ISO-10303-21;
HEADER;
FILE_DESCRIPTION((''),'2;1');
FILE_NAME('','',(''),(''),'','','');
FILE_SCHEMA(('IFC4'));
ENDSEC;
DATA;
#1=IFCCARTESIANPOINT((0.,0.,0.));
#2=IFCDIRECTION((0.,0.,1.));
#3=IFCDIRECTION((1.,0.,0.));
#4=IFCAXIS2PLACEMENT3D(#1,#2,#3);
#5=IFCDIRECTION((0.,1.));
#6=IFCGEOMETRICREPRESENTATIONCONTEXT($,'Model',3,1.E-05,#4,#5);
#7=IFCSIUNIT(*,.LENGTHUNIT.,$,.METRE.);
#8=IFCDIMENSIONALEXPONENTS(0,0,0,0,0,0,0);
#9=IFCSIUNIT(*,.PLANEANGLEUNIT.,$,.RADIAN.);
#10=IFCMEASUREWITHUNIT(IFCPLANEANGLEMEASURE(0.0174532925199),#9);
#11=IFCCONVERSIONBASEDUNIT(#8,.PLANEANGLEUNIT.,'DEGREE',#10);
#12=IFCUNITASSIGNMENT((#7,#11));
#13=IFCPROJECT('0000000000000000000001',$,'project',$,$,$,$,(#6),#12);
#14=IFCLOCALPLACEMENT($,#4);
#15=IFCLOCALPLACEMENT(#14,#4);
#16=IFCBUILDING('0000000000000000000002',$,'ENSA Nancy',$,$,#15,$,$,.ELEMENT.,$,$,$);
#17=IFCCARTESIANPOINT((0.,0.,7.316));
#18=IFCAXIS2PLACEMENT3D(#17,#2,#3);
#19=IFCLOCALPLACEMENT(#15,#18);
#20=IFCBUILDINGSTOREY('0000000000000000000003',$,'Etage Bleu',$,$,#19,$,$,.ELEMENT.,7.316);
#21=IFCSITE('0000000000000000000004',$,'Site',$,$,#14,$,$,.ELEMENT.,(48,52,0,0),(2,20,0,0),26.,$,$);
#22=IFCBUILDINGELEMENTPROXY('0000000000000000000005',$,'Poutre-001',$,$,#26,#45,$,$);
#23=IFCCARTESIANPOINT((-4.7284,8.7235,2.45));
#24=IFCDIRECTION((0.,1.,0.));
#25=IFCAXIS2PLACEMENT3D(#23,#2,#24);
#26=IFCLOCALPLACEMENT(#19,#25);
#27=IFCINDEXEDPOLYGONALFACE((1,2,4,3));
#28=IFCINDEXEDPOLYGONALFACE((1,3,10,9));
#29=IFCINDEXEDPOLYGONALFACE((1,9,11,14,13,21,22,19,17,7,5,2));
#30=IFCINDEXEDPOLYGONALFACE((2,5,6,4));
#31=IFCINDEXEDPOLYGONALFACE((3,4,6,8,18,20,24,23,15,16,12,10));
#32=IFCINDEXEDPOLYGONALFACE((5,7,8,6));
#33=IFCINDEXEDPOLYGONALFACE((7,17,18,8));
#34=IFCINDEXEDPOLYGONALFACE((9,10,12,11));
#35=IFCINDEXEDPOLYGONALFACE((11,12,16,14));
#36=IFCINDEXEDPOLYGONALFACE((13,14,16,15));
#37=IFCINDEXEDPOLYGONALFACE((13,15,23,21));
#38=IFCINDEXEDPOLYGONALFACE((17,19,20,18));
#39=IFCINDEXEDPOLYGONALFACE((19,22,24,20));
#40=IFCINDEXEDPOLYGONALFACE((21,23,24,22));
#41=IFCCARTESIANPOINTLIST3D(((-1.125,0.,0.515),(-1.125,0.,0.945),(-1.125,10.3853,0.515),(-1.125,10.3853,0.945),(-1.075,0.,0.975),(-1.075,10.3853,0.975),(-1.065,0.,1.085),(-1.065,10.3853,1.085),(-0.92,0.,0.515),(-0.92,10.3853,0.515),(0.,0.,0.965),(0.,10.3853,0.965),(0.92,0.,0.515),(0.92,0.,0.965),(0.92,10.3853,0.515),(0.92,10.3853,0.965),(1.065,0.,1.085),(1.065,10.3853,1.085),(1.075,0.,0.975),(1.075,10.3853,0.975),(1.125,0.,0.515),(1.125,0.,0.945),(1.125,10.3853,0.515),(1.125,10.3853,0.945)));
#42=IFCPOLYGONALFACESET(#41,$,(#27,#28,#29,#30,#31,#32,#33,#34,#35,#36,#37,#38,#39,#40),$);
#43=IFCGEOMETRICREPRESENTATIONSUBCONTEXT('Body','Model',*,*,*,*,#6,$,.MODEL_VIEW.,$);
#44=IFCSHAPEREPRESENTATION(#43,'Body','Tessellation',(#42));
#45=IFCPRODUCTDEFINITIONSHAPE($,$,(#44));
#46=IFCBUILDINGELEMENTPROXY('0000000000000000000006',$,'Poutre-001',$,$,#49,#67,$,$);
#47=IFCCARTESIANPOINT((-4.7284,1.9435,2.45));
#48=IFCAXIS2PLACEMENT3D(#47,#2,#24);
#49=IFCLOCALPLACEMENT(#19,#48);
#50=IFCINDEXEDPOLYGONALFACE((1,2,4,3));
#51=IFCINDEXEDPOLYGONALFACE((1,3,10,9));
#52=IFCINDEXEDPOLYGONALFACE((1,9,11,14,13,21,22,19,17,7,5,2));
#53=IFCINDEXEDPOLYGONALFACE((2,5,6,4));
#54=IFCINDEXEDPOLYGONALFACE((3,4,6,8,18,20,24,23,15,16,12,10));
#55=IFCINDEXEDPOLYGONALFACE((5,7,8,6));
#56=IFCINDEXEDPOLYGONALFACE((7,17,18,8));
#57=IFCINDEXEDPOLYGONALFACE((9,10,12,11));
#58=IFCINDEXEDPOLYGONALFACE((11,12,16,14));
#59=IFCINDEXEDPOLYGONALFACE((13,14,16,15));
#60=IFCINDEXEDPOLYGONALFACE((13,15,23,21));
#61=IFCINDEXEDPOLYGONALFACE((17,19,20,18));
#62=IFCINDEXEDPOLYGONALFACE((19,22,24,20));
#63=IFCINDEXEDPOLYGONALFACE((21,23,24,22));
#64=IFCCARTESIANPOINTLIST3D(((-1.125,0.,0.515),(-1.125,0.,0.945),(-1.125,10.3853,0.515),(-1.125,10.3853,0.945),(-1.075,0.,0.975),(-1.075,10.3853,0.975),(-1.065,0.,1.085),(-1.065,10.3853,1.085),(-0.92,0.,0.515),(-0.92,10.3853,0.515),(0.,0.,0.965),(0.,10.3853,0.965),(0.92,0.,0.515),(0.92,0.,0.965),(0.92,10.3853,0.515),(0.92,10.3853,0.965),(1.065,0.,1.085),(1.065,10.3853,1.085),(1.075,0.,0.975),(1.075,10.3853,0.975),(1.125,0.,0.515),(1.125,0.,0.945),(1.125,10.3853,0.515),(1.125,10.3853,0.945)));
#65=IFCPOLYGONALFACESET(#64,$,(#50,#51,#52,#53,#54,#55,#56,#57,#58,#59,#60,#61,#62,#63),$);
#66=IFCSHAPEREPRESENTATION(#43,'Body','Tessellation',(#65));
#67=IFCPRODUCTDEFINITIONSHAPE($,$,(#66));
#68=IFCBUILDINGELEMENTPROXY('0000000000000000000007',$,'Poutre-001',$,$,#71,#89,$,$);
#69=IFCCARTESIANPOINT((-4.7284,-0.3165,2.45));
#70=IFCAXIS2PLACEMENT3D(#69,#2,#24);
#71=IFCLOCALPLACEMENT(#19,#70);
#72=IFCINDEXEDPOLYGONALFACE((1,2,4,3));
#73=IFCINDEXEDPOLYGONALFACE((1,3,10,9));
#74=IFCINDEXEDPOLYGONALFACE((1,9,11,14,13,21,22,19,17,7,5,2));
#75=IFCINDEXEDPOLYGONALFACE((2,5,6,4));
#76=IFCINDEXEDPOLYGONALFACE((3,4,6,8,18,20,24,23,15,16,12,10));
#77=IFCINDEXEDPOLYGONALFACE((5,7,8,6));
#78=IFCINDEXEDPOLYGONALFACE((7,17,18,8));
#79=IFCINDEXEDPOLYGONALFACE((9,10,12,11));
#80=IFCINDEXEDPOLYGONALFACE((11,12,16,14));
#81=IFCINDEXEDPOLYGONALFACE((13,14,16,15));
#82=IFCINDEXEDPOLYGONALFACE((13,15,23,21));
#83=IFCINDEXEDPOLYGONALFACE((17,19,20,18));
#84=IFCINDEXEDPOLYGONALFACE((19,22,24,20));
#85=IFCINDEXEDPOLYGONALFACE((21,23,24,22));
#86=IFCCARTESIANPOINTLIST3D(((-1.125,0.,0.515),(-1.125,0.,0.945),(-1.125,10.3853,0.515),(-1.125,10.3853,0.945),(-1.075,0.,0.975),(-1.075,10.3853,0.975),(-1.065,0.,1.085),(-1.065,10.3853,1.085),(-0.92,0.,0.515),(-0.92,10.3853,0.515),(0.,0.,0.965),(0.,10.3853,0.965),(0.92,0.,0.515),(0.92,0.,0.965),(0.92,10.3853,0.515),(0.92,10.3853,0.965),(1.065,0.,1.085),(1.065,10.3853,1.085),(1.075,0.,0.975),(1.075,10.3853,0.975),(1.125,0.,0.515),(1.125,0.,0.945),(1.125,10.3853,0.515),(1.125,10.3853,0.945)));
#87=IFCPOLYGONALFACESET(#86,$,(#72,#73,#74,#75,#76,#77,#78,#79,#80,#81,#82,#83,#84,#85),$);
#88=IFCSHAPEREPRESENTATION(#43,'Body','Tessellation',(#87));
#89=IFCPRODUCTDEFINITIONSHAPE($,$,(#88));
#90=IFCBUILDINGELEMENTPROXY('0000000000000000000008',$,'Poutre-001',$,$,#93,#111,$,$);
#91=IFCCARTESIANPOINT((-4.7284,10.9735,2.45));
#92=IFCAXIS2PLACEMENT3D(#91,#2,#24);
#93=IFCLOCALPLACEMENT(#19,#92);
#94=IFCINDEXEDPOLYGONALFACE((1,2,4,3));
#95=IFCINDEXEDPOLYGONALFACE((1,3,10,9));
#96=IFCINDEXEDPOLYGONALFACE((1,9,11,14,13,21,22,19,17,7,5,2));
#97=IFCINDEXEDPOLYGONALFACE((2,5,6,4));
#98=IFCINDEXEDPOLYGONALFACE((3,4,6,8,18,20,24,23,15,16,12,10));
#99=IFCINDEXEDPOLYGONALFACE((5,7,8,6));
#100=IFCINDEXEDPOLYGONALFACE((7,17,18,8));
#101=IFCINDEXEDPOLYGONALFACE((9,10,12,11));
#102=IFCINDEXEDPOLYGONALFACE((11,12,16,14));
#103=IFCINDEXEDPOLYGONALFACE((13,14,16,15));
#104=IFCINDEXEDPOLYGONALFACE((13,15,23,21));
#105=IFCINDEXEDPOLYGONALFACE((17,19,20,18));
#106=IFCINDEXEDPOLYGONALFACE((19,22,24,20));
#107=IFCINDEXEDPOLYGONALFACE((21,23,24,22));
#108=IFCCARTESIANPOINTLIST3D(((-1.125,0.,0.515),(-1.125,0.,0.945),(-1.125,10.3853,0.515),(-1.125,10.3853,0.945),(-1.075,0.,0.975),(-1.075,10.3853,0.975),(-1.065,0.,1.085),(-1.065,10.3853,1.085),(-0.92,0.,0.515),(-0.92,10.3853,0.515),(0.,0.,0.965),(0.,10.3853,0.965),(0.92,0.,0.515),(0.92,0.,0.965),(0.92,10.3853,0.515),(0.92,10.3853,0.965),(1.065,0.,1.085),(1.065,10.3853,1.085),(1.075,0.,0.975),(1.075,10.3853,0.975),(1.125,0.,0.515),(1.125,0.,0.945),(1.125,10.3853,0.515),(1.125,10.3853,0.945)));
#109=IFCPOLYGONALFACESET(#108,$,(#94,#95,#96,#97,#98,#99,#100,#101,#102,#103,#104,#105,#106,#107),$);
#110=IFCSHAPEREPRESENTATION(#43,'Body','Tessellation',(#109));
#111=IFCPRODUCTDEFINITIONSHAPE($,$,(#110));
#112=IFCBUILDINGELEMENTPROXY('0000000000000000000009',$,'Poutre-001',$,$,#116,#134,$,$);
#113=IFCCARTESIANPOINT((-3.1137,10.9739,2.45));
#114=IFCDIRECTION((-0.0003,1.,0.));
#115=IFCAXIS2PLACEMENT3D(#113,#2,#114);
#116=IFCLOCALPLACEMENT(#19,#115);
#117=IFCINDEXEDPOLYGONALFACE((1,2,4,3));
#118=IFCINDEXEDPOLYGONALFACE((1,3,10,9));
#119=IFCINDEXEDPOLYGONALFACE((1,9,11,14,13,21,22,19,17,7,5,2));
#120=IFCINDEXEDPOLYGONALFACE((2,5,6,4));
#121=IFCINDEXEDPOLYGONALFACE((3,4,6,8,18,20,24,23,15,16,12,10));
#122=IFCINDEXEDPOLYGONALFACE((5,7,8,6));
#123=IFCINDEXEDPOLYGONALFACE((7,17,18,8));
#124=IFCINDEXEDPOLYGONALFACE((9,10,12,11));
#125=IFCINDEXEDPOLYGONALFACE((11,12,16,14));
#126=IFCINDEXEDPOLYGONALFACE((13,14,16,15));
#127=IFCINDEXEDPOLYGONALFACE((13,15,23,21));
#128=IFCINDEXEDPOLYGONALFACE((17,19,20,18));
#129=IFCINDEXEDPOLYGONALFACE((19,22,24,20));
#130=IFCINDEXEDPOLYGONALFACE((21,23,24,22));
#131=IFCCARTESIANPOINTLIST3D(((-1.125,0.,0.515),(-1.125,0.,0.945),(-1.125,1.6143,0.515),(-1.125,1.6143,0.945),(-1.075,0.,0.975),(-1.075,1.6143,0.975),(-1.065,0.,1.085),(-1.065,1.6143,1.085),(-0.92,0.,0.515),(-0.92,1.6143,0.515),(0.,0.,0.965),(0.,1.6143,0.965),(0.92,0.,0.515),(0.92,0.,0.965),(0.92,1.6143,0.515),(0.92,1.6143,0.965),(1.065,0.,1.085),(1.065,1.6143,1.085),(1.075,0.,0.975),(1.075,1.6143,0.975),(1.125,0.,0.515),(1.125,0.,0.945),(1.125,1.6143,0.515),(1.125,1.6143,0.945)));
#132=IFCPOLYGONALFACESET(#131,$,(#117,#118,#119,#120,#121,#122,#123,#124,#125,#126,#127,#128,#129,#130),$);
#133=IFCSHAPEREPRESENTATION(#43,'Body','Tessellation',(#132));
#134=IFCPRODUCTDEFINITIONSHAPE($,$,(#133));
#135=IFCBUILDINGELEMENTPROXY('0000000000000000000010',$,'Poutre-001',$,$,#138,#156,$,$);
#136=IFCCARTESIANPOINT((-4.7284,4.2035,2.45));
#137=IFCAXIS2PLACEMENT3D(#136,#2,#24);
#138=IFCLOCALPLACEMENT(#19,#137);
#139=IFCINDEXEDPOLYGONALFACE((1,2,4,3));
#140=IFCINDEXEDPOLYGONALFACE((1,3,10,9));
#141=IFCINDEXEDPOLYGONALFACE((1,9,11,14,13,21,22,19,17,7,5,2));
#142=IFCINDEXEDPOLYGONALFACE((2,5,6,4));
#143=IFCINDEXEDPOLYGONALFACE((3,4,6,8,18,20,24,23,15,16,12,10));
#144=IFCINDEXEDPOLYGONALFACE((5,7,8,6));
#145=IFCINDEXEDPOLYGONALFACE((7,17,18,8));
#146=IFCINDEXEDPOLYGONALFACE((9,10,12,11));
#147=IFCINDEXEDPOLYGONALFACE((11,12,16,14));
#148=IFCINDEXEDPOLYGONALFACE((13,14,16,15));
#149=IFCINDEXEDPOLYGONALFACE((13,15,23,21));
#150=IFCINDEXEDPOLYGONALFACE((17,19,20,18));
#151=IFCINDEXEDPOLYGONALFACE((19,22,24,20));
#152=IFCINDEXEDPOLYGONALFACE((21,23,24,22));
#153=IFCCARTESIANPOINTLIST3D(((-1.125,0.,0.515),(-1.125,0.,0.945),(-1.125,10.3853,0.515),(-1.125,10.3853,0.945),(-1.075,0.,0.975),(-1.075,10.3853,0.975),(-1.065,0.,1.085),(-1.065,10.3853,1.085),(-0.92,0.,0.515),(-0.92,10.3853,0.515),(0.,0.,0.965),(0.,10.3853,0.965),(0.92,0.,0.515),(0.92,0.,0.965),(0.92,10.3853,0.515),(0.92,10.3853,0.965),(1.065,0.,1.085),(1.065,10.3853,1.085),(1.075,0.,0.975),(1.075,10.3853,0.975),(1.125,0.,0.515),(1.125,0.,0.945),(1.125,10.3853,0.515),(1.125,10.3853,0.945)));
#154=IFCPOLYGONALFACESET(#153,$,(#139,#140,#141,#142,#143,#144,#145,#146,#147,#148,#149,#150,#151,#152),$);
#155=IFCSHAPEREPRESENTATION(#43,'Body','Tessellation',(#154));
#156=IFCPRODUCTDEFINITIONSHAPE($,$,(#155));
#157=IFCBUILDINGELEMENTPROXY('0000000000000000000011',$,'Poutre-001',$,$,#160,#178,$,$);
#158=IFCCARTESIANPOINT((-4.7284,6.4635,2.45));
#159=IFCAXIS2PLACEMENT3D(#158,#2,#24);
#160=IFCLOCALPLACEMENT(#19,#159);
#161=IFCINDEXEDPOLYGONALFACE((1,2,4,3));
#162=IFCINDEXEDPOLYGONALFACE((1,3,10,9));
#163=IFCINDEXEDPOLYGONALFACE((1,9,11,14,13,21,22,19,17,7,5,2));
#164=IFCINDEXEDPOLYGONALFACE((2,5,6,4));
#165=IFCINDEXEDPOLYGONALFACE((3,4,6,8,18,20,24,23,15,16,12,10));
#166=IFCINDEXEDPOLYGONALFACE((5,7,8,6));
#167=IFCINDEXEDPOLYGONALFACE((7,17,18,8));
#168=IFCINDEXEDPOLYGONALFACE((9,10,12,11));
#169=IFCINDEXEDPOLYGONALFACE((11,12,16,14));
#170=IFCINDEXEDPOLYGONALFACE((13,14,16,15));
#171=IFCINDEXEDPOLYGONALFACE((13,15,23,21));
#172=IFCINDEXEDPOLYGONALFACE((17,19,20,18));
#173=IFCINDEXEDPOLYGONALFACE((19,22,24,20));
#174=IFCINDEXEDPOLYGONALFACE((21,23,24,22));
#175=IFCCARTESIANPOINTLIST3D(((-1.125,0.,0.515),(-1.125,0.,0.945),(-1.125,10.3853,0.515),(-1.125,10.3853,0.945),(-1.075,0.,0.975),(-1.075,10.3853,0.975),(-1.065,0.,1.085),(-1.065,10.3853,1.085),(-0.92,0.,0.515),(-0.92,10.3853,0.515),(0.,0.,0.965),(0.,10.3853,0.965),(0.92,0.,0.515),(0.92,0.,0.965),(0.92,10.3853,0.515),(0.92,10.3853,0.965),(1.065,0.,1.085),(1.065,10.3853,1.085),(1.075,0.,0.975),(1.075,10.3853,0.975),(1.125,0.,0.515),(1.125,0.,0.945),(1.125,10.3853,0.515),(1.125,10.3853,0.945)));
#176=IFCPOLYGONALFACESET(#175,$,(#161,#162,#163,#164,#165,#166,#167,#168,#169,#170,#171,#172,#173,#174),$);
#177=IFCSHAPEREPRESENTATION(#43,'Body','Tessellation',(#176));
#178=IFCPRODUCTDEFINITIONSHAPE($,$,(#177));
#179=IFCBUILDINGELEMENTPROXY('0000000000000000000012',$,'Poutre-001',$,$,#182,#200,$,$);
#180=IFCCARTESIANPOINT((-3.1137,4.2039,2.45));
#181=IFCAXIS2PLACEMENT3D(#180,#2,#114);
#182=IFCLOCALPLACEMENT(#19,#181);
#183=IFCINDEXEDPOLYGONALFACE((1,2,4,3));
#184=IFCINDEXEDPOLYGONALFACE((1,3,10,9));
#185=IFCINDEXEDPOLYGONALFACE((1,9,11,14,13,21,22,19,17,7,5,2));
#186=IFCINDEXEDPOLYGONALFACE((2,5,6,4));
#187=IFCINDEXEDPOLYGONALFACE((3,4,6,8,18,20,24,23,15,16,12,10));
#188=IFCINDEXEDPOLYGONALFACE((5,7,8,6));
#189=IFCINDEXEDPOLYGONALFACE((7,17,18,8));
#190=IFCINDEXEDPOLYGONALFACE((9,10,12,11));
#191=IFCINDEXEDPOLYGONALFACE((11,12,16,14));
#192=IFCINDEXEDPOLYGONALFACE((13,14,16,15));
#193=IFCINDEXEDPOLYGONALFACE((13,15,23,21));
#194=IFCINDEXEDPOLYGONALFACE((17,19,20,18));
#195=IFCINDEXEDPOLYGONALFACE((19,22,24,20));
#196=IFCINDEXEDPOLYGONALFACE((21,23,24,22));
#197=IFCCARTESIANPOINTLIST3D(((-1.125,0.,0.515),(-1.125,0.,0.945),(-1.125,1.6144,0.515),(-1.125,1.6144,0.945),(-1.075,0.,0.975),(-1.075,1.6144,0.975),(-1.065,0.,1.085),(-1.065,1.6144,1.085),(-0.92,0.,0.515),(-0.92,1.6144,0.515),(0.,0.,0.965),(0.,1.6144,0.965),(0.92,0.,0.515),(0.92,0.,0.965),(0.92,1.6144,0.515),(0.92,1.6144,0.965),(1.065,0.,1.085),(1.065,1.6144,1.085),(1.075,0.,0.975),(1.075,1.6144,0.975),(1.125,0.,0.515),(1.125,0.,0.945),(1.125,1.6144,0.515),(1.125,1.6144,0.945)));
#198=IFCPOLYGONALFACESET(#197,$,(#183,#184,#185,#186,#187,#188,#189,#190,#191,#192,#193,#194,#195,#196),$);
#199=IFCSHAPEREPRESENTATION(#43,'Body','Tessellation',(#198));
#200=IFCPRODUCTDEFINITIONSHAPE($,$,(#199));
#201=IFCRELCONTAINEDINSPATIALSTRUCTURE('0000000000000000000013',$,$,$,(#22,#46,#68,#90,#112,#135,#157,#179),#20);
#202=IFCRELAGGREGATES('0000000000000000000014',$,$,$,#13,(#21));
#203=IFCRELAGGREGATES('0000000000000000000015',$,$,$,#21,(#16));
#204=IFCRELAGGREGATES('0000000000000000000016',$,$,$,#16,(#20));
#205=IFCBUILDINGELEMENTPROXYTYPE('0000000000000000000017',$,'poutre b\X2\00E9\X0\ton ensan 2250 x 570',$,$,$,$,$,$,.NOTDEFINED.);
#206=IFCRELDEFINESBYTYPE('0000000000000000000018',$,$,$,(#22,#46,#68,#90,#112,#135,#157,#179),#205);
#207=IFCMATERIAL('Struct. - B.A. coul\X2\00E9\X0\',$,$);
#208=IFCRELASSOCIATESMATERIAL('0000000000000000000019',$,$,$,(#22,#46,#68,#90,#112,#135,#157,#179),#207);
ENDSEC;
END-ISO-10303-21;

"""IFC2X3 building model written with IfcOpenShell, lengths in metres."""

from ifc_helpers import new_model, entity, si_unit, converted_unit, direction, frame, origin_with_axes, place, context, subcontext, project, spatial, polyline, outline, extrude, material, type_object, element, save


model = new_model("IFC2X3")

# Units and contexts
model_context = context("Model", 3, precision=1e-05, world=origin_with_axes(), true_north=direction((0.0, 1.0)))
body_context = subcontext(model_context, "Body", "Model", "MODEL_VIEW")
ifc_project = project(units=[si_unit("LENGTHUNIT", "METRE"), converted_unit("PLANEANGLEUNIT", "DEGREE", entity("IfcPlaneAngleMeasure", 0.0174532925199), si_unit("PLANEANGLEUNIT", "RADIAN"), dimensions=[0, 0, 0, 0, 0, 0, 0])], contexts=[model_context])

# Site, building, storey
site_placement = place(None, origin_with_axes())
site = spatial("IfcSite", under=ifc_project, at=site_placement, Name="Site", CompositionType="ELEMENT", RefLatitude=(48, 52, 0, 0), RefLongitude=(2, 20, 0, 0), RefElevation=26.0)
building_placement = place(site_placement, origin_with_axes())
building = spatial("IfcBuilding", under=site, at=building_placement, Name="ENSA Nancy", CompositionType="ELEMENT")
storey_placement = place(building_placement, frame((0.0, 0.0, 7.316), z_axis=(0.0, 0.0, 1.0), x_axis=(1.0, 0.0, 0.0)))
storey = spatial("IfcBuildingStorey", under=building, at=storey_placement, Name="Etage Bleu", CompositionType="ELEMENT", Elevation=7.316)

# Building element proxies
ifc_material_1 = material(Name="Struct. - B.A. coulé")
building_element_proxy_type_1 = type_object("IfcBuildingElementProxyType", Name="poutre béton ensan 2250 x 570", PredefinedType="NOTDEFINED")
for number, where, z_axis, x_axis, name in (
    (1, (-4.7284, 8.7235, 2.45), (0.0, 0.0, 1.0), (0.0, 1.0, 0.0), "Poutre-001"),
    (2, (-4.7284, 1.9435, 2.45), (0.0, 0.0, 1.0), (0.0, 1.0, 0.0), "Poutre-001"),
    (3, (-4.7284, -0.3165, 2.45), (0.0, 0.0, 1.0), (0.0, 1.0, 0.0), "Poutre-001"),
    (4, (-4.7284, 10.9735, 2.45), (0.0, 0.0, 1.0), (0.0, 1.0, 0.0), "Poutre-001"),
):
    element("IfcBuildingElementProxy", number, at=place(storey_placement, frame(where, z_axis=z_axis, x_axis=x_axis)), inside=storey, type_object=building_element_proxy_type_1, material=ifc_material_1, Name=name, context=body_context, shape_type="SweptSolid", body=[
        extrude(outline(polyline([(-1.065, 1.085), (-1.075, 0.975), (-1.125, 0.945), (-1.125, 0.515), (-0.92, 0.515), (0.0, 0.965), (0.92, 0.965), (0.92, 0.515), (1.125, 0.515), (1.125, 0.945), (1.075, 0.975), (1.065, 1.085), (-1.065, 1.085)])), frame((0.0, 10.3853, 0.0), z_axis=(0.0, -1.0, 0.0), x_axis=(1.0, 0.0, 0.0)), (0.0, 0.0, 1.0), 10.3853),
    ])
proxy_1_placement = place(storey_placement, frame((-3.1137, 10.9739, 2.45), z_axis=(0.0, 0.0, 1.0), x_axis=(-0.0003, 1.0, 0.0)))
element("IfcBuildingElementProxy", 5, at=proxy_1_placement, inside=storey, type_object=building_element_proxy_type_1, material=ifc_material_1, Name="Poutre-001", context=body_context, shape_type="SweptSolid", body=[
    extrude(outline(polyline([(-1.065, 1.085), (-1.075, 0.975), (-1.125, 0.945), (-1.125, 0.515), (-0.92, 0.515), (0.0, 0.965), (0.92, 0.965), (0.92, 0.515), (1.125, 0.515), (1.125, 0.945), (1.075, 0.975), (1.065, 1.085), (-1.065, 1.085)])), frame((0.0, 1.6143, 0.0), z_axis=(0.0, -1.0, 0.0), x_axis=(1.0, 0.0, 0.0)), (0.0, 0.0, 1.0), 1.6143),
])
for number, where, z_axis, x_axis, name in (
    (6, (-4.7284, 4.2035, 2.45), (0.0, 0.0, 1.0), (0.0, 1.0, 0.0), "Poutre-001"),
    (7, (-4.7284, 6.4635, 2.45), (0.0, 0.0, 1.0), (0.0, 1.0, 0.0), "Poutre-001"),
):
    element("IfcBuildingElementProxy", number, at=place(storey_placement, frame(where, z_axis=z_axis, x_axis=x_axis)), inside=storey, type_object=building_element_proxy_type_1, material=ifc_material_1, Name=name, context=body_context, shape_type="SweptSolid", body=[
        extrude(outline(polyline([(-1.065, 1.085), (-1.075, 0.975), (-1.125, 0.945), (-1.125, 0.515), (-0.92, 0.515), (0.0, 0.965), (0.92, 0.965), (0.92, 0.515), (1.125, 0.515), (1.125, 0.945), (1.075, 0.975), (1.065, 1.085), (-1.065, 1.085)])), frame((0.0, 10.3853, 0.0), z_axis=(0.0, -1.0, 0.0), x_axis=(1.0, 0.0, 0.0)), (0.0, 0.0, 1.0), 10.3853),
    ])
for number, where, z_axis, x_axis, name in (
    (8, (-3.1137, 4.2039, 2.45), (0.0, 0.0, 1.0), (-0.0003, 1.0, 0.0), "Poutre-001"),
):
    element("IfcBuildingElementProxy", number, at=place(storey_placement, frame(where, z_axis=z_axis, x_axis=x_axis)), inside=storey, type_object=building_element_proxy_type_1, material=ifc_material_1, Name=name, context=body_context, shape_type="SweptSolid", body=[
        extrude(outline(polyline([(-1.065, 1.085), (-1.075, 0.975), (-1.125, 0.945), (-1.125, 0.515), (-0.92, 0.515), (0.0, 0.965), (0.92, 0.965), (0.92, 0.515), (1.125, 0.515), (1.125, 0.945), (1.075, 0.975), (1.065, 1.085), (-1.065, 1.085)])), frame((0.0, 1.6144, 0.0), z_axis=(0.0, -1.0, 0.0), x_axis=(1.0, 0.0, 0.0)), (0.0, 0.0, 1.0), 1.6144),
    ])

save(model, "model.ifc")
